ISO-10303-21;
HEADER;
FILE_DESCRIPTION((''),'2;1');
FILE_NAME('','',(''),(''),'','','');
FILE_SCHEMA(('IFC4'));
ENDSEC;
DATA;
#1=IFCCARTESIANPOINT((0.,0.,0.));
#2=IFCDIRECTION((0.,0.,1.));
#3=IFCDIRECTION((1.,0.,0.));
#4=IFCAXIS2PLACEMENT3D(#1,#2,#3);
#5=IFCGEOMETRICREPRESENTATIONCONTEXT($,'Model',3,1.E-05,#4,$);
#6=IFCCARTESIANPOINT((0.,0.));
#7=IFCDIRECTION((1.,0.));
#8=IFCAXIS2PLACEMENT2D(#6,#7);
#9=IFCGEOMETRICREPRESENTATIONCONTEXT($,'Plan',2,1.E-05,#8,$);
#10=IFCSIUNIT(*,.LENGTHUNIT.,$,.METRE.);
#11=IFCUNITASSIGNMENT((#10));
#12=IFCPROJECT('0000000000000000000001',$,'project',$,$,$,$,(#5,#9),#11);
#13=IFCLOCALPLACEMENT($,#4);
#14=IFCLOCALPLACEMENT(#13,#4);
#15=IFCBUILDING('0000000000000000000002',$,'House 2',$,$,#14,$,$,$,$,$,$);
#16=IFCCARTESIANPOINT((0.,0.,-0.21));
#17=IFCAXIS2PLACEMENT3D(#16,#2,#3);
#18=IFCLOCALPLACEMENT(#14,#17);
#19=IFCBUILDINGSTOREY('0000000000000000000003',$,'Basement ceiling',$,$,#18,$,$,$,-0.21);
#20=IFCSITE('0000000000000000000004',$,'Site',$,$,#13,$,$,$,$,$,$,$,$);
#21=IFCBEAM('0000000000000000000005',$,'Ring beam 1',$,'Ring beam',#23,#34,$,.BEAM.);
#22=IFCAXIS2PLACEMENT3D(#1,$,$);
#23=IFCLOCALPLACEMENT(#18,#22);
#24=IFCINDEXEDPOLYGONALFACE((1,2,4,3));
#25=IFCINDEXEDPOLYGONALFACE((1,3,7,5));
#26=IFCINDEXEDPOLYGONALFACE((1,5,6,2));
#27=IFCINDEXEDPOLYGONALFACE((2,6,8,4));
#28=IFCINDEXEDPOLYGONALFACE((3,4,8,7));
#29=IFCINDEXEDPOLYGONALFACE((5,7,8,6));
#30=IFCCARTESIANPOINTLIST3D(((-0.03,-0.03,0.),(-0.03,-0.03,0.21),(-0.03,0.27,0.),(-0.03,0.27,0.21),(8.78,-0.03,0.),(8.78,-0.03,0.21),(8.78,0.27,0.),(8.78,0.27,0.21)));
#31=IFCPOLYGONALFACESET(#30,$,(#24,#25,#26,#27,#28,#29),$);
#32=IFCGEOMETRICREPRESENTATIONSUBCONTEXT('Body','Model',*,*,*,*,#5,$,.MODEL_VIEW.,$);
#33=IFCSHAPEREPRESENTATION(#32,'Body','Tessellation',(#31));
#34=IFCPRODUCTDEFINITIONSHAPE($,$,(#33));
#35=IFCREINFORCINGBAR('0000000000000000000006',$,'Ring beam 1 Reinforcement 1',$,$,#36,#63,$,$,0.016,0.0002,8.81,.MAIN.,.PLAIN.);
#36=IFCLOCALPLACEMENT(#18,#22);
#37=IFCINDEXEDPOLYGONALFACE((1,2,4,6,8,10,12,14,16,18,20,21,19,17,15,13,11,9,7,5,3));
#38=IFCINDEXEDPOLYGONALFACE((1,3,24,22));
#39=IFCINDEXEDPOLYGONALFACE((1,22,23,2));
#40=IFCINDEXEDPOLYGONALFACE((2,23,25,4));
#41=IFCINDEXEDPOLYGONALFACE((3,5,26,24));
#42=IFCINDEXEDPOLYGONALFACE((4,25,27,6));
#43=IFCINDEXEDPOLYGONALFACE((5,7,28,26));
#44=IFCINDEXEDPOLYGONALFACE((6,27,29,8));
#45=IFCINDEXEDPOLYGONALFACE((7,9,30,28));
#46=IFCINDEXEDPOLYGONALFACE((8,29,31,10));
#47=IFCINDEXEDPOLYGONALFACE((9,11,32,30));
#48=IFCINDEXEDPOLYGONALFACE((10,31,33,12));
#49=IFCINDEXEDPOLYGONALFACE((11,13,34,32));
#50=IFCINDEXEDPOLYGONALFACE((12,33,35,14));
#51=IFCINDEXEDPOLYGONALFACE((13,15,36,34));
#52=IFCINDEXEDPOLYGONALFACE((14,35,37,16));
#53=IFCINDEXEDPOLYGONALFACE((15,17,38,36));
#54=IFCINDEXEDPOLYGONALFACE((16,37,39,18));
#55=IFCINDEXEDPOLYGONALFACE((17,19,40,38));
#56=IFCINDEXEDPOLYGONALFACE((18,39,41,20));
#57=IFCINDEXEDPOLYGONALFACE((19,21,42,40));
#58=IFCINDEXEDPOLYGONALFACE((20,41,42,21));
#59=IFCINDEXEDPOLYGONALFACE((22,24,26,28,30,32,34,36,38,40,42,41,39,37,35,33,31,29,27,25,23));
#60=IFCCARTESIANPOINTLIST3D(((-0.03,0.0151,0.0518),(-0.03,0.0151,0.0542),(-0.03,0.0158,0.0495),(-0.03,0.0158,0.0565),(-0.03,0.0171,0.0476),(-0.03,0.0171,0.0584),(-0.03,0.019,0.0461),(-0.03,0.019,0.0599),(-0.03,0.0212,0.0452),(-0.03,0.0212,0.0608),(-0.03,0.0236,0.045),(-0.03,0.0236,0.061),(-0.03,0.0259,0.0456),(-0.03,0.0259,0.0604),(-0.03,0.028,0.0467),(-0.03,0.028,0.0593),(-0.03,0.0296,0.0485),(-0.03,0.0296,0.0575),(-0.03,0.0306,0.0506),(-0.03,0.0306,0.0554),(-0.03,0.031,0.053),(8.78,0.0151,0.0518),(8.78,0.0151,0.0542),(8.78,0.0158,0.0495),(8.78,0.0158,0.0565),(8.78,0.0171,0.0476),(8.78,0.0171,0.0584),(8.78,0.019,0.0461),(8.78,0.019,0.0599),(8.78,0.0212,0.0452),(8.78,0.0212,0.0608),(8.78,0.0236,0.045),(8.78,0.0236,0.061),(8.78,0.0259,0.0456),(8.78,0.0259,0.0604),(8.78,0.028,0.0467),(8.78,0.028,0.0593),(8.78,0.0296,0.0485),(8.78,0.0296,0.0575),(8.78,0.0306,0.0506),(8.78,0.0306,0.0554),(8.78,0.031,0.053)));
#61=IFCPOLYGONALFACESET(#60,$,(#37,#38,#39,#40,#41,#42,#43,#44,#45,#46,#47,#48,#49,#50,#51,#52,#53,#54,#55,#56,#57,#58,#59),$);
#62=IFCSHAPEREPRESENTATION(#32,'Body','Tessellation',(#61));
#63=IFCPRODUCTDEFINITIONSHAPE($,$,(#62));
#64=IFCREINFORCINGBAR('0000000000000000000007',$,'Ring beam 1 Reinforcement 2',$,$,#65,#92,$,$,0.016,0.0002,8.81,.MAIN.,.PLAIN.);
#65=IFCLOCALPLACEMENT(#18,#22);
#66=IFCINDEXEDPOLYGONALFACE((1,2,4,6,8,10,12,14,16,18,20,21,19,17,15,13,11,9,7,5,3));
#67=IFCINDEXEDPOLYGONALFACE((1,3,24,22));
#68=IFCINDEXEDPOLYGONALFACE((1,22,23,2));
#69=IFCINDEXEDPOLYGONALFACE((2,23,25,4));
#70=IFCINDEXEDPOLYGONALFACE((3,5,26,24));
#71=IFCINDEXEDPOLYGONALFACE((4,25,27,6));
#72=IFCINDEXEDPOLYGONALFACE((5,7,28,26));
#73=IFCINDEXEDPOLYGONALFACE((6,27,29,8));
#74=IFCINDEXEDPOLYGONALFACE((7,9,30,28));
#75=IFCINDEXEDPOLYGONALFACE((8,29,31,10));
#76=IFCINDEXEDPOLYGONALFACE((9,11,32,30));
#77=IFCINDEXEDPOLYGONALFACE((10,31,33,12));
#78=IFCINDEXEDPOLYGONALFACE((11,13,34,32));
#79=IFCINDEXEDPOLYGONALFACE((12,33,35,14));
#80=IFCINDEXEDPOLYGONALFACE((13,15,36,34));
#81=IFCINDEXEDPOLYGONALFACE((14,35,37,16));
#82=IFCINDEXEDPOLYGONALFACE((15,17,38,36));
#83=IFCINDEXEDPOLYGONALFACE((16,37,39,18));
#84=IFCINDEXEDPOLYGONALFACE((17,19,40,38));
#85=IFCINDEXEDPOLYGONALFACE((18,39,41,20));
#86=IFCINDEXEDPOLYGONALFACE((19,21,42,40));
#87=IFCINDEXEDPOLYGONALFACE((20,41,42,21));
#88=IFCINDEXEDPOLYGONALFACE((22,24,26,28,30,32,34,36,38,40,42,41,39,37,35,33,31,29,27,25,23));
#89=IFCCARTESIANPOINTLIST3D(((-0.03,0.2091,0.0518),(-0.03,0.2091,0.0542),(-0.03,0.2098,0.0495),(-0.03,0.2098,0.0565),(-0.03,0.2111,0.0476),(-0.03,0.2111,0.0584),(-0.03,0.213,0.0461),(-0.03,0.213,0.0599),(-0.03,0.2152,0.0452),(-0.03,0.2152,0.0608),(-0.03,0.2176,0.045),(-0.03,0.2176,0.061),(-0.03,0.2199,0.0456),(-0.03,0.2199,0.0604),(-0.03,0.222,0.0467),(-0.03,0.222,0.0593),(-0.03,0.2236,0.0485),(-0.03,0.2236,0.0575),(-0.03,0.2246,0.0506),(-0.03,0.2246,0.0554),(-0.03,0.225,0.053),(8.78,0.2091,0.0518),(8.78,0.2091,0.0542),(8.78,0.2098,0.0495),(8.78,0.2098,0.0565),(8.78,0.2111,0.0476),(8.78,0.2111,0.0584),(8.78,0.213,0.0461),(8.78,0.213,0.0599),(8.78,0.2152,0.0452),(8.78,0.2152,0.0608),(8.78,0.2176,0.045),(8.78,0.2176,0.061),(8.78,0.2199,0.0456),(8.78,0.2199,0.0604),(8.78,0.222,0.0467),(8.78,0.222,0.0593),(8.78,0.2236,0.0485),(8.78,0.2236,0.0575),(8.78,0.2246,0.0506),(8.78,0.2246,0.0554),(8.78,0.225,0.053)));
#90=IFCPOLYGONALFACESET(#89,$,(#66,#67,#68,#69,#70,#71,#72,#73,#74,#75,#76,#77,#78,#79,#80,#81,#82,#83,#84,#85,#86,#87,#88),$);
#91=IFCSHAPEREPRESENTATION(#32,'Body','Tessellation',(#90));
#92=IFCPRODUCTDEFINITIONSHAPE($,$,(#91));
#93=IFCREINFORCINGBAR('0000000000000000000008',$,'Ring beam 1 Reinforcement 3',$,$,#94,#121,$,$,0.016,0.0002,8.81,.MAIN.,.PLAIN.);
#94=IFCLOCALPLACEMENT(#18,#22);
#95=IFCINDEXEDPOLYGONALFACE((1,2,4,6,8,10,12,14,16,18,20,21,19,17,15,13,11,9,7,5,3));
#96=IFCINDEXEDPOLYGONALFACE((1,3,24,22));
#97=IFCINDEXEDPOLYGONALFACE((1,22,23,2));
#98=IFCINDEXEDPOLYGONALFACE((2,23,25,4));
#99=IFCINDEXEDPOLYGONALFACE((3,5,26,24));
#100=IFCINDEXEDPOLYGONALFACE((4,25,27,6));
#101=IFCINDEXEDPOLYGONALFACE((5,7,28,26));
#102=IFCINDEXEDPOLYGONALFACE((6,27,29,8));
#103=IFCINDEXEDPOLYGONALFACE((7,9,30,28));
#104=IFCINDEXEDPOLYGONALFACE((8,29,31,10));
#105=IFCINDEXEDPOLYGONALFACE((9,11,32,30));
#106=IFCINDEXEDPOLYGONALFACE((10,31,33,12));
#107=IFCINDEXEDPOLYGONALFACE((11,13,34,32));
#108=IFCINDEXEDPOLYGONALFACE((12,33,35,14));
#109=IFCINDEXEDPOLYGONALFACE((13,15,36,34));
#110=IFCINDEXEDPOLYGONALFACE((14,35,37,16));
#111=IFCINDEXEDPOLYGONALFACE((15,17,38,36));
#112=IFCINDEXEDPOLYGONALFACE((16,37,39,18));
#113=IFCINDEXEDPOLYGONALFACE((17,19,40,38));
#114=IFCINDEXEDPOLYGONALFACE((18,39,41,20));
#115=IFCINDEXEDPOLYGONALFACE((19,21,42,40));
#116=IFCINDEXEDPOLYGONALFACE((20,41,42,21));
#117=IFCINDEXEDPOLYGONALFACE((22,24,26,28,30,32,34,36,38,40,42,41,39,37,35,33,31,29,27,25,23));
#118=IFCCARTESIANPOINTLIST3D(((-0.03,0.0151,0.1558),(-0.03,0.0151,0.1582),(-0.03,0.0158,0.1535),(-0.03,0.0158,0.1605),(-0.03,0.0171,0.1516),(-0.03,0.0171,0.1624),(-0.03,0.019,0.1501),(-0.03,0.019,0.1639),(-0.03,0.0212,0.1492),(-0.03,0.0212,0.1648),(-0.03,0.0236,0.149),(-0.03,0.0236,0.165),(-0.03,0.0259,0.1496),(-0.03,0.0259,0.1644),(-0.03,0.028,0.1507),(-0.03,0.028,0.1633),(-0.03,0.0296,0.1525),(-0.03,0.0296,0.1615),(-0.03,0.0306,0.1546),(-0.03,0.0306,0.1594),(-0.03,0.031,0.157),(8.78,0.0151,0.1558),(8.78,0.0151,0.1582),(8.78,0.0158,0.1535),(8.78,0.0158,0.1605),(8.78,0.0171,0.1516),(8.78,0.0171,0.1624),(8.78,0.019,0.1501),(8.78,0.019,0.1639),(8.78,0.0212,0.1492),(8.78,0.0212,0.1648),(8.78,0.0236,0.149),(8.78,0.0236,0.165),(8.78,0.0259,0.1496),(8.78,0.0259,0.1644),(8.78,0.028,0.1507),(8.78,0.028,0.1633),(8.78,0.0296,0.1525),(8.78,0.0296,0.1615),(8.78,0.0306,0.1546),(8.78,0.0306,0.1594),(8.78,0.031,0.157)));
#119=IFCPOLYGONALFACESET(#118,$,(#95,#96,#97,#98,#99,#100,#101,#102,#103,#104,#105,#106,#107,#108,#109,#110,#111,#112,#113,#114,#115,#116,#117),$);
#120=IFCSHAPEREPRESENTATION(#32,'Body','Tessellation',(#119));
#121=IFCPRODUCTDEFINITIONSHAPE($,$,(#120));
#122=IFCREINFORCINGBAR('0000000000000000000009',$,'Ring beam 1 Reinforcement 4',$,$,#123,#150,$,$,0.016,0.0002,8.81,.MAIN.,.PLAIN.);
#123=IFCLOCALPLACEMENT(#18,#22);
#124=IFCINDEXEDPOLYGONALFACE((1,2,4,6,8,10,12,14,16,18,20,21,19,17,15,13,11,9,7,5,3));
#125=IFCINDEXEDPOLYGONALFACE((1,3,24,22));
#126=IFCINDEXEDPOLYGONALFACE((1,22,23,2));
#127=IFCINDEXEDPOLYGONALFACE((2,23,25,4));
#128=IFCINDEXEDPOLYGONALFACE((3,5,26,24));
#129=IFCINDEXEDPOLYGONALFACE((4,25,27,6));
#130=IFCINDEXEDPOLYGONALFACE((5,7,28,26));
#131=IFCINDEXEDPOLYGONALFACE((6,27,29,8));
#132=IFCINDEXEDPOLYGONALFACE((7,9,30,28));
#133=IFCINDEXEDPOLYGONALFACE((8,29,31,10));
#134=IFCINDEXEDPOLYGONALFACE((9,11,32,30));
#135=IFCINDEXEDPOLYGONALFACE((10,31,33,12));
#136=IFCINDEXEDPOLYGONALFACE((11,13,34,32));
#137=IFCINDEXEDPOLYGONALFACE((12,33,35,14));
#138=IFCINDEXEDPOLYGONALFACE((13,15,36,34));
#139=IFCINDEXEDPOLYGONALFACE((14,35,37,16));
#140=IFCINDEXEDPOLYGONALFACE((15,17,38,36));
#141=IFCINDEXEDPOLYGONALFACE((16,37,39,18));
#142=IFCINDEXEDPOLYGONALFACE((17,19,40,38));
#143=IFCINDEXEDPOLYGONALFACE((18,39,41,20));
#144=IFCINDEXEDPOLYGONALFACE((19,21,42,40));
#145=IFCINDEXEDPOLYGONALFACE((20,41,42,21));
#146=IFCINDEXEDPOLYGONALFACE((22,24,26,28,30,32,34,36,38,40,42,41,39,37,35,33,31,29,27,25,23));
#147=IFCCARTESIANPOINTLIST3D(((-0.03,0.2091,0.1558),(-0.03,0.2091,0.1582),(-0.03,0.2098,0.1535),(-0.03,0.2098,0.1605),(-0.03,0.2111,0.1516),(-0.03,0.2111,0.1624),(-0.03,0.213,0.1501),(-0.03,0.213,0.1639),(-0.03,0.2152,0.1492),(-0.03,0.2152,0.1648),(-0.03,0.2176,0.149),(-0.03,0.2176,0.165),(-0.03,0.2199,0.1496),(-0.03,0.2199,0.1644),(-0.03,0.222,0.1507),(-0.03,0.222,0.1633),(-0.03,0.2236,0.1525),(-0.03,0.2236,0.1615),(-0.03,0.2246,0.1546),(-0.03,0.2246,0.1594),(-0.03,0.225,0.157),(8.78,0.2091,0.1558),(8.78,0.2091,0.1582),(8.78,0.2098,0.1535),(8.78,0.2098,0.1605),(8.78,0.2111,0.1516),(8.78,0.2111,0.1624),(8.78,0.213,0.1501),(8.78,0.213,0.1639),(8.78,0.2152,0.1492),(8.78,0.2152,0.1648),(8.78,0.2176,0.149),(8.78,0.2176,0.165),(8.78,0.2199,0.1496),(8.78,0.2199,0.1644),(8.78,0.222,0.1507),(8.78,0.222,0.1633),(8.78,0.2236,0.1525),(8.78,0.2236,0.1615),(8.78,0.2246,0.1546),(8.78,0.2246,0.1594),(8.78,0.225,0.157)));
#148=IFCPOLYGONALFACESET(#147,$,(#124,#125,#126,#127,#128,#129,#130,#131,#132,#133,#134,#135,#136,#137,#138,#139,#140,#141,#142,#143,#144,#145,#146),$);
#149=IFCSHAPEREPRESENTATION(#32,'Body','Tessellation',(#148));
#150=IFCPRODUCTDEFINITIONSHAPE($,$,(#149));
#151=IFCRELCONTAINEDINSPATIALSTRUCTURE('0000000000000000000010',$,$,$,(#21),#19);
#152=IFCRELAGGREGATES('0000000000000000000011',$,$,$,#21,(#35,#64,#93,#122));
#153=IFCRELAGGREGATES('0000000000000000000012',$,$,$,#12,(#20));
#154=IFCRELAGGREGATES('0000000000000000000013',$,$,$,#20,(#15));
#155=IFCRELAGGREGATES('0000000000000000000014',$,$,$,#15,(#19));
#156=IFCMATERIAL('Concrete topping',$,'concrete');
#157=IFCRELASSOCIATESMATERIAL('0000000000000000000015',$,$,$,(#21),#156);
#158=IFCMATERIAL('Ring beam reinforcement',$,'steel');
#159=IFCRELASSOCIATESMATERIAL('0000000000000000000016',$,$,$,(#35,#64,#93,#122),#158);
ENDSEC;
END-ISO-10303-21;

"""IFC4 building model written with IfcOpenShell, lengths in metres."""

from ifc_helpers import new_model, si_unit, frame, origin_with_axes, origin_2d, origin_2d_with_axis, place, context, subcontext, project, spatial, circle_curve, rectangle, outline, extrude, material, element, aggregate, save


model = new_model("IFC4")

# Units and contexts
model_context = context("Model", 3, precision=1e-05, world=origin_with_axes())
plan_context = context("Plan", 2, precision=1e-05, world=origin_2d_with_axis())
body_context = subcontext(model_context, "Body", "Model", "MODEL_VIEW")
ifc_project = project(units=[si_unit("LENGTHUNIT", "METRE")], contexts=[model_context, plan_context])

# Site, building, storey
site_placement = place(None, origin_with_axes())
site = spatial("IfcSite", under=ifc_project, at=site_placement, Name="Site")
building_placement = place(site_placement, origin_with_axes())
building = spatial("IfcBuilding", under=site, at=building_placement, Name="House 2")
storey_placement = place(building_placement, frame((0.0, 0.0, -0.21), z_axis=(0.0, 0.0, 1.0), x_axis=(1.0, 0.0, 0.0)))
storey = spatial("IfcBuildingStorey", under=building, at=storey_placement, Name="Basement ceiling", Elevation=-0.21)

# Beam
ifc_material_1 = material(Name="Concrete topping", Category="concrete")
beam_1_placement = place(storey_placement, frame((-0.03, 0.12, 0.105), z_axis=(0.0, 0.0, 1.0), x_axis=(1.0, 0.0, 0.0)))
beam_1 = element("IfcBeam", 1, at=beam_1_placement, inside=storey, material=ifc_material_1, Name="Ring beam 1", ObjectType="Ring beam", PredefinedType="BEAM", context=body_context, shape_type="SweptSolid", body=[
    extrude(rectangle(XDim=0.3, YDim=0.21), frame((0.0, 0.0, 0.0), z_axis=(1.0, 0.0, 0.0), x_axis=(0.0, 1.0, 0.0)), (0.0, 0.0, 1.0), 8.81),
])

# Reinforcing bars
ifc_material_2 = material(Name="Ring beam reinforcement", Category="steel")
reinforcing_bar_1_placement = place(beam_1_placement, frame((0.0, -0.097, -0.052), z_axis=(0.0, 0.0, 1.0), x_axis=(1.0, 0.0, 0.0)))
reinforcing_bar_1 = element("IfcReinforcingBar", 2, at=reinforcing_bar_1_placement, material=ifc_material_2, Name="Ring beam 1 Reinforcement 1", BarLength=8.81, BarSurface="PLAIN", CrossSectionArea=0.0002, NominalDiameter=0.016, PredefinedType="MAIN", context=body_context, shape_type="SweptSolid", body=[
    extrude(outline(circle_curve(origin_2d(), 0.008)), frame((0.0, 0.0, 0.0), z_axis=(1.0, 0.0, 0.0), x_axis=(0.0, 1.0, 0.0)), (0.0, 0.0, 1.0), 8.81),
])
reinforcing_bar_2_placement = place(beam_1_placement, frame((0.0, 0.097, -0.052), z_axis=(0.0, 0.0, 1.0), x_axis=(1.0, 0.0, 0.0)))
reinforcing_bar_2 = element("IfcReinforcingBar", 3, at=reinforcing_bar_2_placement, material=ifc_material_2, Name="Ring beam 1 Reinforcement 2", BarLength=8.81, BarSurface="PLAIN", CrossSectionArea=0.0002, NominalDiameter=0.016, PredefinedType="MAIN", context=body_context, shape_type="SweptSolid", body=[
    extrude(outline(circle_curve(origin_2d(), 0.008)), frame((0.0, 0.0, 0.0), z_axis=(1.0, 0.0, 0.0), x_axis=(0.0, 1.0, 0.0)), (0.0, 0.0, 1.0), 8.81),
])
reinforcing_bar_3_placement = place(beam_1_placement, frame((0.0, -0.097, 0.052), z_axis=(0.0, 0.0, 1.0), x_axis=(1.0, 0.0, 0.0)))
reinforcing_bar_3 = element("IfcReinforcingBar", 4, at=reinforcing_bar_3_placement, material=ifc_material_2, Name="Ring beam 1 Reinforcement 3", BarLength=8.81, BarSurface="PLAIN", CrossSectionArea=0.0002, NominalDiameter=0.016, PredefinedType="MAIN", context=body_context, shape_type="SweptSolid", body=[
    extrude(outline(circle_curve(origin_2d(), 0.008)), frame((0.0, 0.0, 0.0), z_axis=(1.0, 0.0, 0.0), x_axis=(0.0, 1.0, 0.0)), (0.0, 0.0, 1.0), 8.81),
])
reinforcing_bar_4_placement = place(beam_1_placement, frame((0.0, 0.097, 0.052), z_axis=(0.0, 0.0, 1.0), x_axis=(1.0, 0.0, 0.0)))
reinforcing_bar_4 = element("IfcReinforcingBar", 5, at=reinforcing_bar_4_placement, material=ifc_material_2, Name="Ring beam 1 Reinforcement 4", BarLength=8.81, BarSurface="PLAIN", CrossSectionArea=0.0002, NominalDiameter=0.016, PredefinedType="MAIN", context=body_context, shape_type="SweptSolid", body=[
    extrude(outline(circle_curve(origin_2d(), 0.008)), frame((0.0, 0.0, 0.0), z_axis=(1.0, 0.0, 0.0), x_axis=(0.0, 1.0, 0.0)), (0.0, 0.0, 1.0), 8.81),
])
aggregate(beam_1, [reinforcing_bar_1, reinforcing_bar_2, reinforcing_bar_3, reinforcing_bar_4])

save(model, "model.ifc")
